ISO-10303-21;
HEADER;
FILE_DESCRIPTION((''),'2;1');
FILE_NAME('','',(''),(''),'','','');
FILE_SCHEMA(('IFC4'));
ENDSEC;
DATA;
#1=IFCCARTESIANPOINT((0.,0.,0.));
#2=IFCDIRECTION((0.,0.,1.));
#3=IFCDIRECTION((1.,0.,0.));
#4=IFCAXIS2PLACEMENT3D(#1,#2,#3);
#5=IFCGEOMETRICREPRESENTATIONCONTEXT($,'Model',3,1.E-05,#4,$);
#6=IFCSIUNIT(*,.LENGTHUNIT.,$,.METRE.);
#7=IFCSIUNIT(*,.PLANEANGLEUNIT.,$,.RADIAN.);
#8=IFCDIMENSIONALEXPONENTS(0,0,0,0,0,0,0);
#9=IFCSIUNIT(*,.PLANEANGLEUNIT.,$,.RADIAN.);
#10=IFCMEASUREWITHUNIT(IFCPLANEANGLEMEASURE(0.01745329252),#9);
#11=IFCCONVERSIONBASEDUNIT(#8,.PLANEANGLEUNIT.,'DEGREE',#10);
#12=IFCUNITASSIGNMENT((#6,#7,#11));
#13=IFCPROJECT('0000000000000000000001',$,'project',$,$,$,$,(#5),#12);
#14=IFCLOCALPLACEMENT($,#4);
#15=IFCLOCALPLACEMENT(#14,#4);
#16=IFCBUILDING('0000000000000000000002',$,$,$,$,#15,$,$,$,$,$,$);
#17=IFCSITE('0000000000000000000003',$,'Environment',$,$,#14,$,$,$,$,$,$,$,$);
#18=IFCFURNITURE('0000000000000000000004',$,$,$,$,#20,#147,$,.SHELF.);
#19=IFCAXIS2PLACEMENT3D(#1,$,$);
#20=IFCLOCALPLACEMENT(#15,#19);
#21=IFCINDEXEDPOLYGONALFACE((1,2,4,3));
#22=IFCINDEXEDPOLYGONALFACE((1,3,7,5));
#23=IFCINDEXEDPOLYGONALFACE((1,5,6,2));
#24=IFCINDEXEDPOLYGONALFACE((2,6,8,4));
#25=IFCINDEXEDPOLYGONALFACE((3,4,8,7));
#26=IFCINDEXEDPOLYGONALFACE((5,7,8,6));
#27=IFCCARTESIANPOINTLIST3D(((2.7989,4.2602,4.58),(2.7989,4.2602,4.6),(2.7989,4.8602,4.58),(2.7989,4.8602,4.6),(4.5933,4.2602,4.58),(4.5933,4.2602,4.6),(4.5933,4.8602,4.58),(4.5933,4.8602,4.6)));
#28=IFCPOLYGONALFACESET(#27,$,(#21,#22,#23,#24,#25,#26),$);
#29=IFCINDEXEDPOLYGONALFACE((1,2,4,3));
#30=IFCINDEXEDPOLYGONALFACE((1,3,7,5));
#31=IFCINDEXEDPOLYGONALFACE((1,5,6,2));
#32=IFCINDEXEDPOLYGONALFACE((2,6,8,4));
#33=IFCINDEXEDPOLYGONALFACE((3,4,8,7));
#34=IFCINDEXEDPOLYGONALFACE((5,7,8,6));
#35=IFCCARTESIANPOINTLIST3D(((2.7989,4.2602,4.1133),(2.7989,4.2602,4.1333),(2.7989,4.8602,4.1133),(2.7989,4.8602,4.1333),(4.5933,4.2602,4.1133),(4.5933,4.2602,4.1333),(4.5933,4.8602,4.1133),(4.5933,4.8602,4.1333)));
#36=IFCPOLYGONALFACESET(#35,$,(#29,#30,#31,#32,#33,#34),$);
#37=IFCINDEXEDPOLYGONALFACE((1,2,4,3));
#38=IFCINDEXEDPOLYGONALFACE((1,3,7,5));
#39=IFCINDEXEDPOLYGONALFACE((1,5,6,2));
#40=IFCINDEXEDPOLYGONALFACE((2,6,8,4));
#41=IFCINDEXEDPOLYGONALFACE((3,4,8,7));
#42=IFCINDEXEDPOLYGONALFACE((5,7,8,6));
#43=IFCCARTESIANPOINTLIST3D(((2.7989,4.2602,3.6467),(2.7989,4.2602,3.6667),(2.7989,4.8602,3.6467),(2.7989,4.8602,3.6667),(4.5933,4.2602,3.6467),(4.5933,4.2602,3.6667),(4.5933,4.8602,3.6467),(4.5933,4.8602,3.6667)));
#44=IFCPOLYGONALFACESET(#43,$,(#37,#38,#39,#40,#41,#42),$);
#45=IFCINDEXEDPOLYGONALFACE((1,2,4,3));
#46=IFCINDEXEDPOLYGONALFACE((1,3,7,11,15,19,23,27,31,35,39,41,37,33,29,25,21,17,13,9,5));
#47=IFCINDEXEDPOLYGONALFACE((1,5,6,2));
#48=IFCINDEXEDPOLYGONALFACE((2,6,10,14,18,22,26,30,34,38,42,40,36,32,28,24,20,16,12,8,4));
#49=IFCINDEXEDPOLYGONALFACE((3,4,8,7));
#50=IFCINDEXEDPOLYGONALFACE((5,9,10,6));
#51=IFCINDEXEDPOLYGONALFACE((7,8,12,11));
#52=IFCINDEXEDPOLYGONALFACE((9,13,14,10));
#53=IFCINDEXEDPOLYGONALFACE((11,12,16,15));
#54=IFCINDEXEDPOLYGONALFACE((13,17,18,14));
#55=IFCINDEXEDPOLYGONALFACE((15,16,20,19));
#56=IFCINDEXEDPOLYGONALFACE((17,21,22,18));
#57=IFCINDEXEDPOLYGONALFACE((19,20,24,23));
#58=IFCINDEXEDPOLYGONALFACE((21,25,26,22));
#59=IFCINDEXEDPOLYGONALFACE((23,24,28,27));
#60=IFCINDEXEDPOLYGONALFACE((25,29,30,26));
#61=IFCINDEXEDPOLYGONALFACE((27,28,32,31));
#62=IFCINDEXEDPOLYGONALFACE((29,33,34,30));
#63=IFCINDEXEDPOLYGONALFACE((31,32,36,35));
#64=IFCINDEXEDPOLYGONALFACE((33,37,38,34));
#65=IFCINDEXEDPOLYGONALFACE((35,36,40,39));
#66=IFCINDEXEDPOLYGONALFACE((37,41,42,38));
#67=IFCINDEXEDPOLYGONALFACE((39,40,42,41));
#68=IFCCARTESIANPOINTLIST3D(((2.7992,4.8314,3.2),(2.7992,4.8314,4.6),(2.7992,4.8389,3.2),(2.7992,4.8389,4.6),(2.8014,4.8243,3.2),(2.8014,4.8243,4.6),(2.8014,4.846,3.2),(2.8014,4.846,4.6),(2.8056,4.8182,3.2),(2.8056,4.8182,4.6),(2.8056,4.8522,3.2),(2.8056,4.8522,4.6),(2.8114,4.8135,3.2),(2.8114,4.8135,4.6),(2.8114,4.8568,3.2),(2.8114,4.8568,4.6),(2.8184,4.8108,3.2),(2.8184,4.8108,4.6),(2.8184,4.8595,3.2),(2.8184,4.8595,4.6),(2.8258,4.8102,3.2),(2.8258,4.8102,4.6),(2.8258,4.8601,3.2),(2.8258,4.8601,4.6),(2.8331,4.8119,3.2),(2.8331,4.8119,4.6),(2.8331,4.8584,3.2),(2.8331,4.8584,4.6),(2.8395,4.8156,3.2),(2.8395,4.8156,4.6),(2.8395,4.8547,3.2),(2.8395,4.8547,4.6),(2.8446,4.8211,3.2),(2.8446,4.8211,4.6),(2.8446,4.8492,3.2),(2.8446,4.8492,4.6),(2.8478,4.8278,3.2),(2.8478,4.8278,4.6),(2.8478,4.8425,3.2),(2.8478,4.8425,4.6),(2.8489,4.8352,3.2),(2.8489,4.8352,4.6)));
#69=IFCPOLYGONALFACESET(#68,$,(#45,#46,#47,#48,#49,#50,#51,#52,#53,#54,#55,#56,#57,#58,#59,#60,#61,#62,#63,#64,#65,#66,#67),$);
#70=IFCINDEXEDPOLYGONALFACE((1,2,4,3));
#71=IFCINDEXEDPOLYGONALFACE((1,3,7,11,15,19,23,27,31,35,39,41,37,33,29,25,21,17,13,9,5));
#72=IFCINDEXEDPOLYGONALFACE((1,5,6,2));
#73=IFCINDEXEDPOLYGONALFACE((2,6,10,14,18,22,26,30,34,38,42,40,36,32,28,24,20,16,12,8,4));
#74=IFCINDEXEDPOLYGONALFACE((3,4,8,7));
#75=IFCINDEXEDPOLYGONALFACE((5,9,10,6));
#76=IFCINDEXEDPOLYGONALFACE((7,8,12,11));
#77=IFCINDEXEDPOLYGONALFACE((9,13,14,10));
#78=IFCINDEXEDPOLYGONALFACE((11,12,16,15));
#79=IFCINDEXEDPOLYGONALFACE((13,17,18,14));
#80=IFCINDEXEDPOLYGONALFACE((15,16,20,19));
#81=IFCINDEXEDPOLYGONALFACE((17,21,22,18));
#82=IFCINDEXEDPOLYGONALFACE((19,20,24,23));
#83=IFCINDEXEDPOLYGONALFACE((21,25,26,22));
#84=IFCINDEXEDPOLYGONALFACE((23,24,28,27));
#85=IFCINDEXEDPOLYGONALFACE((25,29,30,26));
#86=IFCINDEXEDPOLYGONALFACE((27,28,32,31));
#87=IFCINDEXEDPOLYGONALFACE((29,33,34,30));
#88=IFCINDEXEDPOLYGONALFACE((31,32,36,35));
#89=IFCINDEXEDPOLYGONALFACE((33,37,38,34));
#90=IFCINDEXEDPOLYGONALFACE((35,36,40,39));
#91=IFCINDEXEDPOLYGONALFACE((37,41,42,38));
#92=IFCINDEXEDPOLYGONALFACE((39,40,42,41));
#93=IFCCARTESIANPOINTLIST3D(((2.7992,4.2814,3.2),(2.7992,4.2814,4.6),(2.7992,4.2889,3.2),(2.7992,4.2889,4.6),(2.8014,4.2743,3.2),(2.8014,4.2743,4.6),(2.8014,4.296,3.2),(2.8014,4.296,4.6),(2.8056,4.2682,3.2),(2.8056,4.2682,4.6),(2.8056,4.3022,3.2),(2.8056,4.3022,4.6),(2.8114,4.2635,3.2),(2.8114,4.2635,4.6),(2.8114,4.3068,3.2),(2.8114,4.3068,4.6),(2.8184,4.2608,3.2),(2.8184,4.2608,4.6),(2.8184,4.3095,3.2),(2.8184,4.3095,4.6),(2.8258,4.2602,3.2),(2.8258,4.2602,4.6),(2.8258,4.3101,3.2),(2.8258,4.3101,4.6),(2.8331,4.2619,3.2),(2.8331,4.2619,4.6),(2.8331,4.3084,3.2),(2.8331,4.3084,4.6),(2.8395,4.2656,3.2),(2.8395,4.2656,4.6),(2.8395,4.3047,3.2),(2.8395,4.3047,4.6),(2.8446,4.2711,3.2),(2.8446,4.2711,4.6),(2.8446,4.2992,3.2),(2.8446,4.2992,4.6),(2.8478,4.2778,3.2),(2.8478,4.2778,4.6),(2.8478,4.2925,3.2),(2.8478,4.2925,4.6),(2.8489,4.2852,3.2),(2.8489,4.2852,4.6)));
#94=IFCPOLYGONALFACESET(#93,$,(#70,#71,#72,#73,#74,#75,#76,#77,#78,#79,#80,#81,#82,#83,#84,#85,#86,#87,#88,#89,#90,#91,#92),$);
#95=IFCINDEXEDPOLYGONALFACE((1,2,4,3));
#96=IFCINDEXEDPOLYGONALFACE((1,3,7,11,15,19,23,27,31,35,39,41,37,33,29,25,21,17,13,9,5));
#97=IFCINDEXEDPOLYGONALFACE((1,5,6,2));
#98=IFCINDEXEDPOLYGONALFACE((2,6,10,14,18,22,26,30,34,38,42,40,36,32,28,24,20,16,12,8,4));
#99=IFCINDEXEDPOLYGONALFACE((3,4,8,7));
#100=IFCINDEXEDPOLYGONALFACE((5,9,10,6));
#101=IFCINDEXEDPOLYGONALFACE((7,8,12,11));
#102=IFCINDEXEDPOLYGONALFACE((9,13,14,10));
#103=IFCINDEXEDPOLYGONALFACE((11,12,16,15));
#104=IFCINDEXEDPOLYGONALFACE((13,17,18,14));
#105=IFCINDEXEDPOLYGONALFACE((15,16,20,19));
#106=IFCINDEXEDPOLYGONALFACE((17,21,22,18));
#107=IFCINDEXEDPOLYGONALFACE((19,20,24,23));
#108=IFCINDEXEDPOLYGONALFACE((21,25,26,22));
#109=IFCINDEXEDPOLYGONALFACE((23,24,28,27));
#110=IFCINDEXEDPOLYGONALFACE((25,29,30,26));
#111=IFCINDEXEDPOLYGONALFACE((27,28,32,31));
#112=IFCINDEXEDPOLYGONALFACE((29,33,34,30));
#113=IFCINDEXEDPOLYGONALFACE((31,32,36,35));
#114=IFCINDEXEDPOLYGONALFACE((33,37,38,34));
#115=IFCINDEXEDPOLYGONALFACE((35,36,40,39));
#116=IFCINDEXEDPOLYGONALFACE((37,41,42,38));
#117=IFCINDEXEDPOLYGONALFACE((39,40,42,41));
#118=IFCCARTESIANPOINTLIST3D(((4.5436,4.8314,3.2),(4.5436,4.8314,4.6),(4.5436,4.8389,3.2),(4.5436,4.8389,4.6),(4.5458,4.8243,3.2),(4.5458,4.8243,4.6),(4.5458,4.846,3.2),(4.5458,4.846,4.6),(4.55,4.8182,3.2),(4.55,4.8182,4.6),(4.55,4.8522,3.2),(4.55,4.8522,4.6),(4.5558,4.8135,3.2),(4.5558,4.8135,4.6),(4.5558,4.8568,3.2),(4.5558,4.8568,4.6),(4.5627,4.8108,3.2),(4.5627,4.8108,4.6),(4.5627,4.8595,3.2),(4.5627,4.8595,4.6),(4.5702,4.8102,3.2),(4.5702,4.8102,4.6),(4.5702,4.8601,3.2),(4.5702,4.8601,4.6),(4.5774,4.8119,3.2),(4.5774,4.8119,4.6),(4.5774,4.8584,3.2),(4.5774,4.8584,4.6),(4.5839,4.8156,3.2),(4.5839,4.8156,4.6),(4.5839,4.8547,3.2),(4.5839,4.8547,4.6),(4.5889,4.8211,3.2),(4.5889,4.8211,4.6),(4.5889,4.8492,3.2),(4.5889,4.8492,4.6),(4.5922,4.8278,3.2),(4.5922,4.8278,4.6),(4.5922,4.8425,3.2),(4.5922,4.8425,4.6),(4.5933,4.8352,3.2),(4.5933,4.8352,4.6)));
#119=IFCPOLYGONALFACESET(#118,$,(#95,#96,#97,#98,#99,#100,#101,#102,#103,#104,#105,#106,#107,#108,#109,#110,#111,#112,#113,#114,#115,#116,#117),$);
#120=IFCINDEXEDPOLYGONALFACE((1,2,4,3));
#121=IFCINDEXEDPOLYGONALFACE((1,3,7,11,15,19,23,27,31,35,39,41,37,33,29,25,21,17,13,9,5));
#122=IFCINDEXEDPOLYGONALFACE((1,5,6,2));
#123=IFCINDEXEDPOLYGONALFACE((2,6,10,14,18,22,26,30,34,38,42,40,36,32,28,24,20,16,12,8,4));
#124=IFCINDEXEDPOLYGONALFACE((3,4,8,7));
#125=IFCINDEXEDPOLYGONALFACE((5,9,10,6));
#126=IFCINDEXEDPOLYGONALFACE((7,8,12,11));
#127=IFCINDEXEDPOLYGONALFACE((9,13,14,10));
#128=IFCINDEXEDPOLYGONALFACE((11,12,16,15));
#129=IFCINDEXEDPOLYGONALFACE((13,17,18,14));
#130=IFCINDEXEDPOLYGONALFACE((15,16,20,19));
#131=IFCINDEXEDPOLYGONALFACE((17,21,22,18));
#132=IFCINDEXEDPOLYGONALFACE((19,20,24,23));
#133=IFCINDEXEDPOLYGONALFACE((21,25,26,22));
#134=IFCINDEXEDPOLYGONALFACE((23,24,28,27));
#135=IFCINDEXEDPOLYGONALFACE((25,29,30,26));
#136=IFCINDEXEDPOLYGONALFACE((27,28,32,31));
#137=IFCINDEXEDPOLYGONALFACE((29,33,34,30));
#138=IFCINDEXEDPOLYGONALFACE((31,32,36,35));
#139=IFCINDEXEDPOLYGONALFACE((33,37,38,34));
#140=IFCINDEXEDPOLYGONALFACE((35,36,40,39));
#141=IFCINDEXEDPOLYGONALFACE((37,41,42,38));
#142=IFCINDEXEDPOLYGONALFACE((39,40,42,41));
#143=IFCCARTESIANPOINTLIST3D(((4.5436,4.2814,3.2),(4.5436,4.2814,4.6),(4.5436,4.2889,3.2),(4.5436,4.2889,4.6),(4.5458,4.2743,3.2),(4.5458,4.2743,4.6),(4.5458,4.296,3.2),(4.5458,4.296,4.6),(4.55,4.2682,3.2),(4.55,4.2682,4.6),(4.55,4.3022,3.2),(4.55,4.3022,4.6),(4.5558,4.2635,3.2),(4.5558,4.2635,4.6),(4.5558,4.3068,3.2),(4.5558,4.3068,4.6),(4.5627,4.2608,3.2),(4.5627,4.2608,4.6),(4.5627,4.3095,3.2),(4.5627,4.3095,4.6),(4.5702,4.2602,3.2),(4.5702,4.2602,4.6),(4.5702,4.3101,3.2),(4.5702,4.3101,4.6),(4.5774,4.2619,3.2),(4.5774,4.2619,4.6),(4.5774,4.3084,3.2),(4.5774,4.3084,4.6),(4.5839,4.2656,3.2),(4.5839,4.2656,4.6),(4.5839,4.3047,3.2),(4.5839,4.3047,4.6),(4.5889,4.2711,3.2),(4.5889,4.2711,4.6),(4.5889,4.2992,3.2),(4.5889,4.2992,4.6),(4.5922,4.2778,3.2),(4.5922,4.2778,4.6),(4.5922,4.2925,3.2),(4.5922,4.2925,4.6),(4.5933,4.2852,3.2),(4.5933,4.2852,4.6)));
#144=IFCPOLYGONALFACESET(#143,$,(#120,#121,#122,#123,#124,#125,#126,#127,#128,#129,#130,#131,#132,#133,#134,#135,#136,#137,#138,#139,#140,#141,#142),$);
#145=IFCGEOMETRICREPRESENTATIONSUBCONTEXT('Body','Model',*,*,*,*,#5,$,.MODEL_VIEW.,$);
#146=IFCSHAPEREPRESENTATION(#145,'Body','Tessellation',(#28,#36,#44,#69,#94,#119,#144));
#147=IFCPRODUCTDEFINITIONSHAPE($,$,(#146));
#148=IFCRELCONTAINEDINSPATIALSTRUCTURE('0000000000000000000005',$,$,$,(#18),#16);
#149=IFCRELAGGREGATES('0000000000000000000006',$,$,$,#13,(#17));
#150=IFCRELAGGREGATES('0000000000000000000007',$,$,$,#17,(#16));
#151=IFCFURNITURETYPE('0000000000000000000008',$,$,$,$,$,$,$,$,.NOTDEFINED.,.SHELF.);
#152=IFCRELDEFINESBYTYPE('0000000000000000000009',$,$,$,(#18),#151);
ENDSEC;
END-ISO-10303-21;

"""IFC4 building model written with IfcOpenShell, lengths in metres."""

from ifc_helpers import new_model, entity, si_unit, converted_unit, frame, origin_with_axes, origin_2d_with_axis, place, context, subcontext, project, spatial, polyline, circle, outline, extrude, type_object, element, save


model = new_model("IFC4")

# Units and contexts
model_context = context("Model", 3, precision=1e-05, world=origin_with_axes())
body_context = subcontext(model_context, "Body", "Model", "MODEL_VIEW")
ifc_project = project(units=[si_unit("LENGTHUNIT", "METRE"), si_unit("PLANEANGLEUNIT", "RADIAN"), converted_unit("PLANEANGLEUNIT", "DEGREE", entity("IfcPlaneAngleMeasure", 0.01745329252), si_unit("PLANEANGLEUNIT", "RADIAN"), dimensions=[0, 0, 0, 0, 0, 0, 0])], contexts=[model_context])

# Site, building
site_placement = place(None, origin_with_axes())
site = spatial("IfcSite", under=ifc_project, at=site_placement, Name="Environment")
building_placement = place(site_placement, origin_with_axes())
building = spatial("IfcBuilding", under=site, at=building_placement)

# Furniture
furniture_type_1 = type_object("IfcFurnitureType", PredefinedType="SHELF")
furniture_1_placement = place(building_placement, frame((3.6961, 4.5602, 3.2), z_axis=(0.0, 0.0, 1.0), x_axis=(1.0, 0.0, 0.0)))
element("IfcFurniture", 1, at=furniture_1_placement, inside=building, type_object=furniture_type_1, PredefinedType="SHELF", context=body_context, shape_type="SolidModel", body=[
    extrude(outline(polyline([(-0.8972, -0.3), (0.8972, -0.3), (0.8972, 0.3), (-0.8972, 0.3), (-0.8972, -0.3)])), frame((0.0, 0.0, 1.38), z_axis=(0.0, 0.0, 1.0), x_axis=(1.0, 0.0, 0.0)), (0.0, 0.0, 1.0), 0.02),
    extrude(outline(polyline([(-0.8972, -0.3), (0.8972, -0.3), (0.8972, 0.3), (-0.8972, 0.3), (-0.8972, -0.3)])), frame((0.0, 0.0, 0.9133), z_axis=(0.0, 0.0, 1.0), x_axis=(1.0, 0.0, 0.0)), (0.0, 0.0, 1.0), 0.02),
    extrude(outline(polyline([(-0.8972, -0.3), (0.8972, -0.3), (0.8972, 0.3), (-0.8972, 0.3), (-0.8972, -0.3)])), frame((0.0, 0.0, 0.4467), z_axis=(0.0, 0.0, 1.0), x_axis=(1.0, 0.0, 0.0)), (0.0, 0.0, 1.0), 0.02),
    extrude(circle(Radius=0.025, at=origin_2d_with_axis()), frame((-0.8722, 0.275, 0.0), z_axis=(0.0, 0.0, 1.0), x_axis=(1.0, 0.0, 0.0)), (0.0, 0.0, 1.0), 1.4),
    extrude(circle(Radius=0.025, at=origin_2d_with_axis()), frame((-0.8722, -0.275, 0.0), z_axis=(0.0, 0.0, 1.0), x_axis=(1.0, 0.0, 0.0)), (0.0, 0.0, 1.0), 1.4),
    extrude(circle(Radius=0.025, at=origin_2d_with_axis()), frame((0.8722, 0.275, 0.0), z_axis=(0.0, 0.0, 1.0), x_axis=(1.0, 0.0, 0.0)), (0.0, 0.0, 1.0), 1.4),
    extrude(circle(Radius=0.025, at=origin_2d_with_axis()), frame((0.8722, -0.275, 0.0), z_axis=(0.0, 0.0, 1.0), x_axis=(1.0, 0.0, 0.0)), (0.0, 0.0, 1.0), 1.4),
])

save(model, "model.ifc")
